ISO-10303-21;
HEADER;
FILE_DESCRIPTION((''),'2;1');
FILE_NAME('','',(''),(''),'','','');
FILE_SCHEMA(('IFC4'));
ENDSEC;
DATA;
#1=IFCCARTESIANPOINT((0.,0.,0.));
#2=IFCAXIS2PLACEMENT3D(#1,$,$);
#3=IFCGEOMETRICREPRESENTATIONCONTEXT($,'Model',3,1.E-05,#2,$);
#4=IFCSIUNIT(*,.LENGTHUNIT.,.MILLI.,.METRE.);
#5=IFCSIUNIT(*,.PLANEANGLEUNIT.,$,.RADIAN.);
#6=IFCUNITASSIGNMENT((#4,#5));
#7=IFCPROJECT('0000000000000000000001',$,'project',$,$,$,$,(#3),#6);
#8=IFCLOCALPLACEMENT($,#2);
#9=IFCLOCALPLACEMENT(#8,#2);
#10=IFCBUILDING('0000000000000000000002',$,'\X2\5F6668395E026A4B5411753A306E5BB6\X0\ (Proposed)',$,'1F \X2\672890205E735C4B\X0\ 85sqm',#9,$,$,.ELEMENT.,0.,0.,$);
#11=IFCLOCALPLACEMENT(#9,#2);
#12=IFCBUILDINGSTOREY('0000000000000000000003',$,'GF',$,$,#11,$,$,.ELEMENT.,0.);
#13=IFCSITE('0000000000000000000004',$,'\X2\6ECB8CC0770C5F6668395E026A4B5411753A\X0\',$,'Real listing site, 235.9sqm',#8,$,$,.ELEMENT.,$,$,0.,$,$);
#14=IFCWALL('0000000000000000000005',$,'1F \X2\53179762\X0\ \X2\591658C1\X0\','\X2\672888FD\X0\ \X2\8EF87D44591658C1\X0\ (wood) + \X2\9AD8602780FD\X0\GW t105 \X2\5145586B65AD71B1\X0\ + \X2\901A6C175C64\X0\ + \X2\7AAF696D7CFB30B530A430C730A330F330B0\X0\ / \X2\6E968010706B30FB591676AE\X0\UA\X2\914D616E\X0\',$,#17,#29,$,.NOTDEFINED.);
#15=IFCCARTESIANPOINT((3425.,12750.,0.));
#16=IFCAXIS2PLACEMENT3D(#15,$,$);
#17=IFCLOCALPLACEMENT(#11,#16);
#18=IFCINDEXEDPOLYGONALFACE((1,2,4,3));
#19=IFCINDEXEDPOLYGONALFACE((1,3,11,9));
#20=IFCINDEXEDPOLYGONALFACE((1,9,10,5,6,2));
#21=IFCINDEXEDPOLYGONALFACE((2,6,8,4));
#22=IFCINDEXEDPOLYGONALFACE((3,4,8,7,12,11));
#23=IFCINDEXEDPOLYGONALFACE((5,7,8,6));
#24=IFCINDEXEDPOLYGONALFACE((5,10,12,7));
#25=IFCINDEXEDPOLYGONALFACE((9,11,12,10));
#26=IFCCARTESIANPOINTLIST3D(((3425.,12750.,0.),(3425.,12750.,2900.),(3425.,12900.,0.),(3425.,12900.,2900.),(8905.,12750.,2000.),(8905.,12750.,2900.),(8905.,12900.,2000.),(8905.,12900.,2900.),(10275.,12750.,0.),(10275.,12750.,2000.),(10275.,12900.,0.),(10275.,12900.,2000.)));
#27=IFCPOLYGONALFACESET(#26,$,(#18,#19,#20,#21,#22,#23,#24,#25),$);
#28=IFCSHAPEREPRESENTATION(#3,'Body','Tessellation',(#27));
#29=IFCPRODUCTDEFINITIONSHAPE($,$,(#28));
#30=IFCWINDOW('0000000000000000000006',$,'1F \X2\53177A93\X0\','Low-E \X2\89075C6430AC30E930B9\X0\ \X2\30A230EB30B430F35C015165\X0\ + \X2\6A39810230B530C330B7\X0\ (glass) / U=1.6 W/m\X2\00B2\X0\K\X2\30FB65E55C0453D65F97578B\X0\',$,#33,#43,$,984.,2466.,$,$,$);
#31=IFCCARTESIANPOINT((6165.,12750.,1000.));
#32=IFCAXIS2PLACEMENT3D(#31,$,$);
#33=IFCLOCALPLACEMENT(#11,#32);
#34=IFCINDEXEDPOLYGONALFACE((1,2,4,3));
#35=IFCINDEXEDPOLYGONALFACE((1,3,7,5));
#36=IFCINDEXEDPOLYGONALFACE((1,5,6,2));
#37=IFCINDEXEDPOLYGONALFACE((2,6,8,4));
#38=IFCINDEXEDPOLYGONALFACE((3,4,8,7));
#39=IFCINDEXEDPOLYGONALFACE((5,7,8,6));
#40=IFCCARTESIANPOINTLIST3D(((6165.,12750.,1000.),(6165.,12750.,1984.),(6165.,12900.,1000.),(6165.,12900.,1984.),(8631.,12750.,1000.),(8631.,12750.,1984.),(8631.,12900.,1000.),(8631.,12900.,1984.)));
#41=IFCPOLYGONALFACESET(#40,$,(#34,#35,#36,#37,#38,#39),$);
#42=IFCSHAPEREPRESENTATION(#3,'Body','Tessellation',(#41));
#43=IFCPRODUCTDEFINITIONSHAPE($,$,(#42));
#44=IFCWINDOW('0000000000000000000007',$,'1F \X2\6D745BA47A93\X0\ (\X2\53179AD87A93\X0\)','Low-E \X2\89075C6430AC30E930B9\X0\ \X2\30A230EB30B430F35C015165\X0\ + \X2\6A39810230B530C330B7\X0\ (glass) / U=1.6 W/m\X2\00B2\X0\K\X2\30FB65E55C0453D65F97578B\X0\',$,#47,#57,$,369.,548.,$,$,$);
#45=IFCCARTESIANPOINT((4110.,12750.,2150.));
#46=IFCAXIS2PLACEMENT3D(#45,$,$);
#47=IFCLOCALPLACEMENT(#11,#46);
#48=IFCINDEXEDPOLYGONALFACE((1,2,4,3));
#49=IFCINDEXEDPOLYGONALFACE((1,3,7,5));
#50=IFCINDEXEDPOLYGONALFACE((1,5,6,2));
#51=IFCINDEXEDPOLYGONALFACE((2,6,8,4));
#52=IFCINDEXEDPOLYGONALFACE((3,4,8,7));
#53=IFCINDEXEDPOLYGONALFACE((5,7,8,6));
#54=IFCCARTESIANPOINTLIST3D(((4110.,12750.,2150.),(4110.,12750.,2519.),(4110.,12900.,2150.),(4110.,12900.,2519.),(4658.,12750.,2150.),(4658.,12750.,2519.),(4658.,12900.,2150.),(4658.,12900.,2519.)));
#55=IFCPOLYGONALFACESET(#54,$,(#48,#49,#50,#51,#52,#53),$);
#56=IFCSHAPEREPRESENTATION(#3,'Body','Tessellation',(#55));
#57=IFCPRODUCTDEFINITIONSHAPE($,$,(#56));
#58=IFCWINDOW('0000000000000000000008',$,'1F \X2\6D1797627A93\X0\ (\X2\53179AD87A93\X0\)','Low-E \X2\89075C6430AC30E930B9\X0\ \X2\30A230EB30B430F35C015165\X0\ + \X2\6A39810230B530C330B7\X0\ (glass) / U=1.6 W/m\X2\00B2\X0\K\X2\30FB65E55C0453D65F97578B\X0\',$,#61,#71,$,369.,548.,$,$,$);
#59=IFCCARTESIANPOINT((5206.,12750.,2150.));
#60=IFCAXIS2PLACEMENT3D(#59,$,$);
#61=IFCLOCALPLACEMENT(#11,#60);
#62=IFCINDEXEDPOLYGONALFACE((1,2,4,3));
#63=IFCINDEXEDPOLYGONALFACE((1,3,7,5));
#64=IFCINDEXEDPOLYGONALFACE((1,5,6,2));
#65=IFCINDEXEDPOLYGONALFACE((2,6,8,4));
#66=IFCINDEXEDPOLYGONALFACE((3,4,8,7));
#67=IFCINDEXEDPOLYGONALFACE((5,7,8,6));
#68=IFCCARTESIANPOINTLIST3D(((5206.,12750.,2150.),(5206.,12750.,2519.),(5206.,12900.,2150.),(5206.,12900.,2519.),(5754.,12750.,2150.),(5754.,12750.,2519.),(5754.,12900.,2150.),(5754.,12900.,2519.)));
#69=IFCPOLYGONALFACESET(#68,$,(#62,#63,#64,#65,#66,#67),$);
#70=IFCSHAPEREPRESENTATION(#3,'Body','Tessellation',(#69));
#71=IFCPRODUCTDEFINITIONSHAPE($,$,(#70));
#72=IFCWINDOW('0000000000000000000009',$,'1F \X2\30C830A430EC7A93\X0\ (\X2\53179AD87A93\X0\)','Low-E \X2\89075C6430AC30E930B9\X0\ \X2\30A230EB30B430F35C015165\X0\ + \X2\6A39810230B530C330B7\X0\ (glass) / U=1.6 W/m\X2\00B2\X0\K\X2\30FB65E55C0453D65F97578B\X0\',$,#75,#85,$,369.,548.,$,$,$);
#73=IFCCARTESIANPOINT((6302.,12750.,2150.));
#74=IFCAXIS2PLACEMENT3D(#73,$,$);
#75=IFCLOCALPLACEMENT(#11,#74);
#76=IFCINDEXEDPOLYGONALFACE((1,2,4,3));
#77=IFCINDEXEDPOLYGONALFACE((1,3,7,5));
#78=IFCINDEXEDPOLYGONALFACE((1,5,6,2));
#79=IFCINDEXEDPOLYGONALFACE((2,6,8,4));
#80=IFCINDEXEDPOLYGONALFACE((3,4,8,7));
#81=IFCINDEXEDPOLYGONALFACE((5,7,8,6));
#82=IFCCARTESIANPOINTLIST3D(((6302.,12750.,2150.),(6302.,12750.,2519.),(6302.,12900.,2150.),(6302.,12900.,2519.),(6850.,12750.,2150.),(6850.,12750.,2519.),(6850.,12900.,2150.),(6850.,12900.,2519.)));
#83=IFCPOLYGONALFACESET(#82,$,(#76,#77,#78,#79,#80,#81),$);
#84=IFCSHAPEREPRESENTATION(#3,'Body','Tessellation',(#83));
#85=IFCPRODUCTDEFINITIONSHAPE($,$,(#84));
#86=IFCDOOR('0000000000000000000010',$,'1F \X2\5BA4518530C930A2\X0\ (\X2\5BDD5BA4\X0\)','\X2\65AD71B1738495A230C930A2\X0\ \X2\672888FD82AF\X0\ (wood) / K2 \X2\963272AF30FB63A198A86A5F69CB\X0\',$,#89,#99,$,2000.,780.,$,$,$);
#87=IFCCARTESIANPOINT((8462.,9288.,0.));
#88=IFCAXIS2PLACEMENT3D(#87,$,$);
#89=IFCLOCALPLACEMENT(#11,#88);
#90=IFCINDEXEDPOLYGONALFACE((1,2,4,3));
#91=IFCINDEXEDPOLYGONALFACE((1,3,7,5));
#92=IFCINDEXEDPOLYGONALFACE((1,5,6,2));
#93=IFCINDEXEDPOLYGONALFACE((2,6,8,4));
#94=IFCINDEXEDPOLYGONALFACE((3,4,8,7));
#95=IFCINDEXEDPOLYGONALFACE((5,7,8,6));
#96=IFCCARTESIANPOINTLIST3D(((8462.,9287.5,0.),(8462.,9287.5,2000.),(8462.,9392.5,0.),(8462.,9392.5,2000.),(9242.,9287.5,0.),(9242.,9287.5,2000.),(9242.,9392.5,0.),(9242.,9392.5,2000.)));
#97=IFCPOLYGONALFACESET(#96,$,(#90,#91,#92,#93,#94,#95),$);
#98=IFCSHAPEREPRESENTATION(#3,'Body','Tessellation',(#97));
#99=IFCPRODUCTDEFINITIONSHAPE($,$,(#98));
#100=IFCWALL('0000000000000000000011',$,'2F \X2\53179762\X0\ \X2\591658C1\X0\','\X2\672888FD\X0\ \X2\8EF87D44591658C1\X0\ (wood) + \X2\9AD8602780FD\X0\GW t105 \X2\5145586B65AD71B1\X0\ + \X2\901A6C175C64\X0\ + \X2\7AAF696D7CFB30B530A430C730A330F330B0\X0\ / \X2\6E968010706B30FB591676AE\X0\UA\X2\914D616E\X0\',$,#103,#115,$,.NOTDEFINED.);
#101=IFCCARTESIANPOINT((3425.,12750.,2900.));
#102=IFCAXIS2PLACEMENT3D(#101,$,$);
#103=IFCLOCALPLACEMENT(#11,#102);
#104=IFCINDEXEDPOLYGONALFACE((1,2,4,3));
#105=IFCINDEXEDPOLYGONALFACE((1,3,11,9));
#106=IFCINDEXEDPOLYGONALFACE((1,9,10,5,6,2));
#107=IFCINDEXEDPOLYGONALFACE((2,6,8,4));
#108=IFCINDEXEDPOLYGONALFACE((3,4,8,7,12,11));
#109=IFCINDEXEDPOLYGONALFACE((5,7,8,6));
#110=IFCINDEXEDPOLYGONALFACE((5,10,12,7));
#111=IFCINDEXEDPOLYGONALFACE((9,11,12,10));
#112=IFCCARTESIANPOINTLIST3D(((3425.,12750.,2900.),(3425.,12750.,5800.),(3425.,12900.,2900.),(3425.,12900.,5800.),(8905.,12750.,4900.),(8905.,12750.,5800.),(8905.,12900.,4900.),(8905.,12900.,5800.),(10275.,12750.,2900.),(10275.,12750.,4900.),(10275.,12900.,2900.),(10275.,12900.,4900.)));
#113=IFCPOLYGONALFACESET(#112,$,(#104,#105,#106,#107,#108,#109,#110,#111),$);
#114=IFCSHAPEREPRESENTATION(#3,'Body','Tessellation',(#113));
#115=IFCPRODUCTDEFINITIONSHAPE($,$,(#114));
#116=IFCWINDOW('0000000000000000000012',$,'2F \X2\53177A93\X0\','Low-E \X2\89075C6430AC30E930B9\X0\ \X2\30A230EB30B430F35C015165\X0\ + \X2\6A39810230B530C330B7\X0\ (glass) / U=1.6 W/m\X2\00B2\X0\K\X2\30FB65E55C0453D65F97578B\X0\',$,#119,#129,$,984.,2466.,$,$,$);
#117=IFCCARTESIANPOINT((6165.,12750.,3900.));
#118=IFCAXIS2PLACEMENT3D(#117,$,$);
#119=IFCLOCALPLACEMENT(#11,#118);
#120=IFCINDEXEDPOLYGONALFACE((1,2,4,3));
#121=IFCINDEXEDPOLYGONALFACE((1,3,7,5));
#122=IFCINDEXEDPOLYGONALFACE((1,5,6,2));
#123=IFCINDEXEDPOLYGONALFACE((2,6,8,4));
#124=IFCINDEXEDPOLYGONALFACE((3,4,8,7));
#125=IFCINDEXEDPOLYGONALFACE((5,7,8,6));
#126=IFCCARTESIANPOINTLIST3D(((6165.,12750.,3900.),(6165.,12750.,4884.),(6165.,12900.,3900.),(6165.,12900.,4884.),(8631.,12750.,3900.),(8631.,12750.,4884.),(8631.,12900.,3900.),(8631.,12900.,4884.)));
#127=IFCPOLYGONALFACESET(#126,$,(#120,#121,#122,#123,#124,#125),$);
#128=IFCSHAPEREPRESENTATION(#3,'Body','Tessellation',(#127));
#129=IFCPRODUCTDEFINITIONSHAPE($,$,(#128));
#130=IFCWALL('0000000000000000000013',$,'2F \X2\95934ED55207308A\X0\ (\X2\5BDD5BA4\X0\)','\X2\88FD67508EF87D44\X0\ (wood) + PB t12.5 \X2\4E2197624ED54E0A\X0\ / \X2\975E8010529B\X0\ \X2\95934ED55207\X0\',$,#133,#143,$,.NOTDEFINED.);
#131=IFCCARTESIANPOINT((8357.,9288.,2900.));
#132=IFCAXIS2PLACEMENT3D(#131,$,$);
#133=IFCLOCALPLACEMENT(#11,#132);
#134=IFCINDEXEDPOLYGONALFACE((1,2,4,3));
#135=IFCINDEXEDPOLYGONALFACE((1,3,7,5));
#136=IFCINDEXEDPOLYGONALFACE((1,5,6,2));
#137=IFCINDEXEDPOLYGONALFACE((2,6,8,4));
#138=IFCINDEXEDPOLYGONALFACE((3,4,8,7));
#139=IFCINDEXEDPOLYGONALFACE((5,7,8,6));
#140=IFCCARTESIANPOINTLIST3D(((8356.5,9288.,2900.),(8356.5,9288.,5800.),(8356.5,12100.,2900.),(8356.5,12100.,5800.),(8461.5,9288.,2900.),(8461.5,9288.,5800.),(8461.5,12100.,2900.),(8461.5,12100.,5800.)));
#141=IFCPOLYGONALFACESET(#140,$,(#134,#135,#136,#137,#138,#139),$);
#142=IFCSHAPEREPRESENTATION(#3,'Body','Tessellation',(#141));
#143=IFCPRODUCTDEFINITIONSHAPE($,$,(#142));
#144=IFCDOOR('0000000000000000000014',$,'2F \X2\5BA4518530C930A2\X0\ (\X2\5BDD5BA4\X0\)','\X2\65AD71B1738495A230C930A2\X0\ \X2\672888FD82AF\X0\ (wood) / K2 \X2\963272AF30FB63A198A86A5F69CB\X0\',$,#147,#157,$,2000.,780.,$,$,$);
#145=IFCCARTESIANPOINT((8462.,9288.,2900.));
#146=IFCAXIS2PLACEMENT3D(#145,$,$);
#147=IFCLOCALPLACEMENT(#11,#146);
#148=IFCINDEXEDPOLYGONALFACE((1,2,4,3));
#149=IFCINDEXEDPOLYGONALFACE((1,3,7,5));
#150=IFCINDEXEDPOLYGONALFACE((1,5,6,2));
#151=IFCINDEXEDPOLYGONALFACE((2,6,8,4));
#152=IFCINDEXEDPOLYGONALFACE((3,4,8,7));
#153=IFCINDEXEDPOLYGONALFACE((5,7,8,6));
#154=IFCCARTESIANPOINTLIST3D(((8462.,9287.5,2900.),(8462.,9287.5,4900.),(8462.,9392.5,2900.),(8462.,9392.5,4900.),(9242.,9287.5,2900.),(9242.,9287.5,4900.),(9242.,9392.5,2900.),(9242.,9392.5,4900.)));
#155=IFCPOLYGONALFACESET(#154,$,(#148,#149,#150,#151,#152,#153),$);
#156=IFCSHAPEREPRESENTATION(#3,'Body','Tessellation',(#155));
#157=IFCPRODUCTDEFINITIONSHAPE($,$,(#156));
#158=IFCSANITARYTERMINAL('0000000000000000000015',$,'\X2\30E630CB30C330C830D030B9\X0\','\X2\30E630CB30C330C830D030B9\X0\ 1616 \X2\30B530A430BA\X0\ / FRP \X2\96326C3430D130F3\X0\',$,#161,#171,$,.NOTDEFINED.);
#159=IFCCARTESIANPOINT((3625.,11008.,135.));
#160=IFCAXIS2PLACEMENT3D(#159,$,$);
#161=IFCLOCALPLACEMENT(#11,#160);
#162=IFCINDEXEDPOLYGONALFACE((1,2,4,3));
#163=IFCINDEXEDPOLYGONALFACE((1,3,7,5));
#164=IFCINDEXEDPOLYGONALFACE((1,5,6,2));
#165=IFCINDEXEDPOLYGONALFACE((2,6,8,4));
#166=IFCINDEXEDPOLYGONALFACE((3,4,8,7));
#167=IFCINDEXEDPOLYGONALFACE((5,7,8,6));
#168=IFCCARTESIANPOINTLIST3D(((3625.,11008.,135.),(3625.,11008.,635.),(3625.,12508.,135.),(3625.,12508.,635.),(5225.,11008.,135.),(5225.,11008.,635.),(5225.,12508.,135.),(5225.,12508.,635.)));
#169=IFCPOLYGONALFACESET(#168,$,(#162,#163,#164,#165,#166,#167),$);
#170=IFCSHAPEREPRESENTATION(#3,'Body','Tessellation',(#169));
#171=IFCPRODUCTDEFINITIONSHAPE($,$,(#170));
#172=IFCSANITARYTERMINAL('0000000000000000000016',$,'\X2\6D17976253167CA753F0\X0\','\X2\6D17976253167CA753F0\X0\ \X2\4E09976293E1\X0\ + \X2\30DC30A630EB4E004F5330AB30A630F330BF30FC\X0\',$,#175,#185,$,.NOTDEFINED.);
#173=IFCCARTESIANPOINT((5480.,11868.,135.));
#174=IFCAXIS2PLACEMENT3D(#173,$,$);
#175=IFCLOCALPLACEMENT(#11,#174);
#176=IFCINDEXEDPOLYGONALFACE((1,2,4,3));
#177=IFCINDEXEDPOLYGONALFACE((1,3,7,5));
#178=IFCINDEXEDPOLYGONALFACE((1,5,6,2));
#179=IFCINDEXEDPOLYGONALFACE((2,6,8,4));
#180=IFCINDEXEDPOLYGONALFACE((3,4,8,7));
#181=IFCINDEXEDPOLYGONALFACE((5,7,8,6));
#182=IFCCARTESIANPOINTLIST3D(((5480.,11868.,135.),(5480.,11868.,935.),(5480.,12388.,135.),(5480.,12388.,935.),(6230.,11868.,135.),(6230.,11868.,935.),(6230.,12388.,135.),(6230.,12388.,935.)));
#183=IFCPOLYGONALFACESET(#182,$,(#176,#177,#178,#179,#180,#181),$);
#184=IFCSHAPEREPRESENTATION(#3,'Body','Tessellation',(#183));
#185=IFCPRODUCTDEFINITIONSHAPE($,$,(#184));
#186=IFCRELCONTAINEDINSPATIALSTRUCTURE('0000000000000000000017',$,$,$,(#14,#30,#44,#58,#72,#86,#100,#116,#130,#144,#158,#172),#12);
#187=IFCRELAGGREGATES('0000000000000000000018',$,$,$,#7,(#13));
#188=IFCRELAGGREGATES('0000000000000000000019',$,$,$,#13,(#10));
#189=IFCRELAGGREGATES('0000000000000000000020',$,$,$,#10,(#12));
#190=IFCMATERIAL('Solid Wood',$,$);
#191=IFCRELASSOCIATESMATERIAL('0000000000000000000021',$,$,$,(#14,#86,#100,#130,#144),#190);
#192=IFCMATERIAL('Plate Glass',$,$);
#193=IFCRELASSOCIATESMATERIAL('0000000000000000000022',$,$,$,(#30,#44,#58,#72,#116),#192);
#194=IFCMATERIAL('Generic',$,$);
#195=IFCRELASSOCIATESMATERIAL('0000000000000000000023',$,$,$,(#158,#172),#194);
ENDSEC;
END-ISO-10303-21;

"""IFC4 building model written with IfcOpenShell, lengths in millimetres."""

from ifc_helpers import new_model, si_unit, frame, frame_2d, origin, place, context, project, spatial, rectangle, extrude, material, element, fill, save


model = new_model("IFC4")

# Units and contexts
model_context = context("Model", 3, precision=1e-05, world=origin())
ifc_project = project(units=[si_unit("LENGTHUNIT", "METRE", prefix="MILLI"), si_unit("PLANEANGLEUNIT", "RADIAN")], contexts=[model_context])

# Site, building, storey
site_placement = place(None, origin())
site = spatial("IfcSite", under=ifc_project, at=site_placement, Name="滋賀県彦根市橋向町", ObjectType="Real listing site, 235.9sqm", CompositionType="ELEMENT", RefElevation=0.0)
building_placement = place(site_placement, origin())
building = spatial("IfcBuilding", under=site, at=building_placement, Name="彦根市橋向町の家 (Proposed)", ObjectType="1F 木造平屋 85sqm", CompositionType="ELEMENT", ElevationOfRefHeight=0.0, ElevationOfTerrain=0.0)
storey_placement = place(building_placement, origin())
storey = spatial("IfcBuildingStorey", under=building, at=storey_placement, Name="GF", CompositionType="ELEMENT", Elevation=0.0)

# Wall, openings, windows
ifc_material_1 = material(Name="Solid Wood")
wall_1_placement = place(storey_placement, frame((3425.0, 12750.0, 0.0)))
wall_1 = element("IfcWall", 1, at=wall_1_placement, inside=storey, material=ifc_material_1, Name="1F 北面 外壁", Description="木製 軸組外壁 (wood) + 高性能GW t105 充填断熱 + 通気層 + 窯業系サイディング / 準耐火・外皮UA配慮", PredefinedType="NOTDEFINED", context=model_context, shape_type="SweptSolid", body=[
    extrude(rectangle(XDim=6850.0, YDim=150.0, at=frame_2d((3425.0, 75.0))), frame((3425.0, 12750.0, 0.0)), (0.0, 0.0, 1.0), 2900.0),
])
opening_1_placement = place(storey_placement, frame((6165.0, 12750.0, 1000.0)))
opening_1 = element("IfcOpeningElement", 2, at=opening_1_placement, cuts=wall_1, PredefinedType="NOTDEFINED", context=model_context, shape_type="SweptSolid", body=[
    extrude(rectangle(XDim=2466.0, YDim=150.0, at=frame_2d((1233.0, 75.0))), frame((6165.0, 12750.0, 1000.0)), (0.0, 0.0, 1.0), 984.0),
])
opening_2_placement = place(storey_placement, frame((4110.0, 12750.0, 2150.0)))
opening_2 = element("IfcOpeningElement", 3, at=opening_2_placement, cuts=wall_1, PredefinedType="NOTDEFINED", context=model_context, shape_type="SweptSolid", body=[
    extrude(rectangle(XDim=548.0, YDim=150.0, at=frame_2d((274.0, 75.0))), frame((4110.0, 12750.0, 2150.0)), (0.0, 0.0, 1.0), 369.0),
])
opening_3_placement = place(storey_placement, frame((5206.0, 12750.0, 2150.0)))
opening_3 = element("IfcOpeningElement", 4, at=opening_3_placement, cuts=wall_1, PredefinedType="NOTDEFINED", context=model_context, shape_type="SweptSolid", body=[
    extrude(rectangle(XDim=548.0, YDim=150.0, at=frame_2d((274.0, 75.0))), frame((5206.0, 12750.0, 2150.0)), (0.0, 0.0, 1.0), 369.0),
])
opening_4_placement = place(storey_placement, frame((6302.0, 12750.0, 2150.0)))
opening_4 = element("IfcOpeningElement", 5, at=opening_4_placement, cuts=wall_1, PredefinedType="NOTDEFINED", context=model_context, shape_type="SweptSolid", body=[
    extrude(rectangle(XDim=548.0, YDim=150.0, at=frame_2d((274.0, 75.0))), frame((6302.0, 12750.0, 2150.0)), (0.0, 0.0, 1.0), 369.0),
])
ifc_material_2 = material(Name="Plate Glass")
window_1_placement = place(storey_placement, frame((6165.0, 12750.0, 1000.0)))
window_1 = element("IfcWindow", 6, at=window_1_placement, inside=storey, material=ifc_material_2, Name="1F 北窓", Description="Low-E 複層ガラス アルゴン封入 + 樹脂サッシ (glass) / U=1.6 W/m²K・日射取得型", OverallHeight=984.0, OverallWidth=2466.0, context=model_context, shape_type="SweptSolid", body=[
    extrude(rectangle(XDim=2466.0, YDim=150.0, at=frame_2d((1233.0, 75.0))), frame((6165.0, 12750.0, 1000.0)), (0.0, 0.0, 1.0), 984.0),
])
fill(opening_1, window_1)
window_2_placement = place(storey_placement, frame((4110.0, 12750.0, 2150.0)))
window_2 = element("IfcWindow", 7, at=window_2_placement, inside=storey, material=ifc_material_2, Name="1F 浴室窓 (北高窓)", Description="Low-E 複層ガラス アルゴン封入 + 樹脂サッシ (glass) / U=1.6 W/m²K・日射取得型", OverallHeight=369.0, OverallWidth=548.0, context=model_context, shape_type="SweptSolid", body=[
    extrude(rectangle(XDim=548.0, YDim=150.0, at=frame_2d((274.0, 75.0))), frame((4110.0, 12750.0, 2150.0)), (0.0, 0.0, 1.0), 369.0),
])
fill(opening_2, window_2)
window_3_placement = place(storey_placement, frame((5206.0, 12750.0, 2150.0)))
window_3 = element("IfcWindow", 8, at=window_3_placement, inside=storey, material=ifc_material_2, Name="1F 洗面窓 (北高窓)", Description="Low-E 複層ガラス アルゴン封入 + 樹脂サッシ (glass) / U=1.6 W/m²K・日射取得型", OverallHeight=369.0, OverallWidth=548.0, context=model_context, shape_type="SweptSolid", body=[
    extrude(rectangle(XDim=548.0, YDim=150.0, at=frame_2d((274.0, 75.0))), frame((5206.0, 12750.0, 2150.0)), (0.0, 0.0, 1.0), 369.0),
])
fill(opening_3, window_3)
window_4_placement = place(storey_placement, frame((6302.0, 12750.0, 2150.0)))
window_4 = element("IfcWindow", 9, at=window_4_placement, inside=storey, material=ifc_material_2, Name="1F トイレ窓 (北高窓)", Description="Low-E 複層ガラス アルゴン封入 + 樹脂サッシ (glass) / U=1.6 W/m²K・日射取得型", OverallHeight=369.0, OverallWidth=548.0, context=model_context, shape_type="SweptSolid", body=[
    extrude(rectangle(XDim=548.0, YDim=150.0, at=frame_2d((274.0, 75.0))), frame((6302.0, 12750.0, 2150.0)), (0.0, 0.0, 1.0), 369.0),
])
fill(opening_4, window_4)

# Door
door_1_placement = place(storey_placement, frame((8462.0, 9288.0, 0.0)))
element("IfcDoor", 10, at=door_1_placement, inside=storey, material=ifc_material_1, Name="1F 室内ドア (寝室)", Description="断熱玄関ドア 木製芯 (wood) / K2 防犯・採風機構", OverallHeight=2000.0, OverallWidth=780.0, context=model_context, shape_type="SweptSolid", body=[
    extrude(rectangle(XDim=780.0, YDim=105.0, at=frame_2d((390.0, 52.0))), frame((8462.0, 9288.0, 0.0)), (0.0, 0.0, 1.0), 2000.0),
])

# Wall, opening, window
wall_2_placement = place(storey_placement, frame((3425.0, 12750.0, 2900.0)))
wall_2 = element("IfcWall", 11, at=wall_2_placement, inside=storey, material=ifc_material_1, Name="2F 北面 外壁", Description="木製 軸組外壁 (wood) + 高性能GW t105 充填断熱 + 通気層 + 窯業系サイディング / 準耐火・外皮UA配慮", PredefinedType="NOTDEFINED", context=model_context, shape_type="SweptSolid", body=[
    extrude(rectangle(XDim=6850.0, YDim=150.0, at=frame_2d((3425.0, 75.0))), frame((3425.0, 12750.0, 2900.0)), (0.0, 0.0, 1.0), 2900.0),
])
opening_5_placement = place(storey_placement, frame((6165.0, 12750.0, 3900.0)))
opening_5 = element("IfcOpeningElement", 12, at=opening_5_placement, cuts=wall_2, PredefinedType="NOTDEFINED", context=model_context, shape_type="SweptSolid", body=[
    extrude(rectangle(XDim=2466.0, YDim=150.0, at=frame_2d((1233.0, 75.0))), frame((6165.0, 12750.0, 3900.0)), (0.0, 0.0, 1.0), 984.0),
])
window_5_placement = place(storey_placement, frame((6165.0, 12750.0, 3900.0)))
window_5 = element("IfcWindow", 13, at=window_5_placement, inside=storey, material=ifc_material_2, Name="2F 北窓", Description="Low-E 複層ガラス アルゴン封入 + 樹脂サッシ (glass) / U=1.6 W/m²K・日射取得型", OverallHeight=984.0, OverallWidth=2466.0, context=model_context, shape_type="SweptSolid", body=[
    extrude(rectangle(XDim=2466.0, YDim=150.0, at=frame_2d((1233.0, 75.0))), frame((6165.0, 12750.0, 3900.0)), (0.0, 0.0, 1.0), 984.0),
])
fill(opening_5, window_5)

# Wall
wall_3_placement = place(storey_placement, frame((8357.0, 9288.0, 2900.0)))
element("IfcWall", 14, at=wall_3_placement, inside=storey, material=ifc_material_1, Name="2F 間仕切り (寝室)", Description="製材軸組 (wood) + PB t12.5 両面仕上 / 非耐力 間仕切", PredefinedType="NOTDEFINED", context=model_context, shape_type="SweptSolid", body=[
    extrude(rectangle(XDim=105.0, YDim=2812.0, at=frame_2d((52.0, 1406.0))), frame((8357.0, 9288.0, 2900.0)), (0.0, 0.0, 1.0), 2900.0),
])

# Door
door_2_placement = place(storey_placement, frame((8462.0, 9288.0, 2900.0)))
element("IfcDoor", 15, at=door_2_placement, inside=storey, material=ifc_material_1, Name="2F 室内ドア (寝室)", Description="断熱玄関ドア 木製芯 (wood) / K2 防犯・採風機構", OverallHeight=2000.0, OverallWidth=780.0, context=model_context, shape_type="SweptSolid", body=[
    extrude(rectangle(XDim=780.0, YDim=105.0, at=frame_2d((390.0, 52.0))), frame((8462.0, 9288.0, 2900.0)), (0.0, 0.0, 1.0), 2000.0),
])

# Sanitary terminals
ifc_material_3 = material(Name="Generic")
sanitary_terminal_1_placement = place(storey_placement, frame((3625.0, 11008.0, 135.0)))
element("IfcSanitaryTerminal", 16, at=sanitary_terminal_1_placement, inside=storey, material=ifc_material_3, Name="ユニットバス", Description="ユニットバス 1616 サイズ / FRP 防水パン", PredefinedType="NOTDEFINED", context=model_context, shape_type="SweptSolid", body=[
    extrude(rectangle(XDim=1600.0, YDim=1500.0, at=frame_2d((800.0, 750.0))), frame((3625.0, 11008.0, 135.0)), (0.0, 0.0, 1.0), 500.0),
])
sanitary_terminal_2_placement = place(storey_placement, frame((5480.0, 11868.0, 135.0)))
element("IfcSanitaryTerminal", 17, at=sanitary_terminal_2_placement, inside=storey, material=ifc_material_3, Name="洗面化粧台", Description="洗面化粧台 三面鏡 + ボウル一体カウンター", PredefinedType="NOTDEFINED", context=model_context, shape_type="SweptSolid", body=[
    extrude(rectangle(XDim=750.0, YDim=520.0, at=frame_2d((375.0, 260.0))), frame((5480.0, 11868.0, 135.0)), (0.0, 0.0, 1.0), 800.0),
])

save(model, "model.ifc")
